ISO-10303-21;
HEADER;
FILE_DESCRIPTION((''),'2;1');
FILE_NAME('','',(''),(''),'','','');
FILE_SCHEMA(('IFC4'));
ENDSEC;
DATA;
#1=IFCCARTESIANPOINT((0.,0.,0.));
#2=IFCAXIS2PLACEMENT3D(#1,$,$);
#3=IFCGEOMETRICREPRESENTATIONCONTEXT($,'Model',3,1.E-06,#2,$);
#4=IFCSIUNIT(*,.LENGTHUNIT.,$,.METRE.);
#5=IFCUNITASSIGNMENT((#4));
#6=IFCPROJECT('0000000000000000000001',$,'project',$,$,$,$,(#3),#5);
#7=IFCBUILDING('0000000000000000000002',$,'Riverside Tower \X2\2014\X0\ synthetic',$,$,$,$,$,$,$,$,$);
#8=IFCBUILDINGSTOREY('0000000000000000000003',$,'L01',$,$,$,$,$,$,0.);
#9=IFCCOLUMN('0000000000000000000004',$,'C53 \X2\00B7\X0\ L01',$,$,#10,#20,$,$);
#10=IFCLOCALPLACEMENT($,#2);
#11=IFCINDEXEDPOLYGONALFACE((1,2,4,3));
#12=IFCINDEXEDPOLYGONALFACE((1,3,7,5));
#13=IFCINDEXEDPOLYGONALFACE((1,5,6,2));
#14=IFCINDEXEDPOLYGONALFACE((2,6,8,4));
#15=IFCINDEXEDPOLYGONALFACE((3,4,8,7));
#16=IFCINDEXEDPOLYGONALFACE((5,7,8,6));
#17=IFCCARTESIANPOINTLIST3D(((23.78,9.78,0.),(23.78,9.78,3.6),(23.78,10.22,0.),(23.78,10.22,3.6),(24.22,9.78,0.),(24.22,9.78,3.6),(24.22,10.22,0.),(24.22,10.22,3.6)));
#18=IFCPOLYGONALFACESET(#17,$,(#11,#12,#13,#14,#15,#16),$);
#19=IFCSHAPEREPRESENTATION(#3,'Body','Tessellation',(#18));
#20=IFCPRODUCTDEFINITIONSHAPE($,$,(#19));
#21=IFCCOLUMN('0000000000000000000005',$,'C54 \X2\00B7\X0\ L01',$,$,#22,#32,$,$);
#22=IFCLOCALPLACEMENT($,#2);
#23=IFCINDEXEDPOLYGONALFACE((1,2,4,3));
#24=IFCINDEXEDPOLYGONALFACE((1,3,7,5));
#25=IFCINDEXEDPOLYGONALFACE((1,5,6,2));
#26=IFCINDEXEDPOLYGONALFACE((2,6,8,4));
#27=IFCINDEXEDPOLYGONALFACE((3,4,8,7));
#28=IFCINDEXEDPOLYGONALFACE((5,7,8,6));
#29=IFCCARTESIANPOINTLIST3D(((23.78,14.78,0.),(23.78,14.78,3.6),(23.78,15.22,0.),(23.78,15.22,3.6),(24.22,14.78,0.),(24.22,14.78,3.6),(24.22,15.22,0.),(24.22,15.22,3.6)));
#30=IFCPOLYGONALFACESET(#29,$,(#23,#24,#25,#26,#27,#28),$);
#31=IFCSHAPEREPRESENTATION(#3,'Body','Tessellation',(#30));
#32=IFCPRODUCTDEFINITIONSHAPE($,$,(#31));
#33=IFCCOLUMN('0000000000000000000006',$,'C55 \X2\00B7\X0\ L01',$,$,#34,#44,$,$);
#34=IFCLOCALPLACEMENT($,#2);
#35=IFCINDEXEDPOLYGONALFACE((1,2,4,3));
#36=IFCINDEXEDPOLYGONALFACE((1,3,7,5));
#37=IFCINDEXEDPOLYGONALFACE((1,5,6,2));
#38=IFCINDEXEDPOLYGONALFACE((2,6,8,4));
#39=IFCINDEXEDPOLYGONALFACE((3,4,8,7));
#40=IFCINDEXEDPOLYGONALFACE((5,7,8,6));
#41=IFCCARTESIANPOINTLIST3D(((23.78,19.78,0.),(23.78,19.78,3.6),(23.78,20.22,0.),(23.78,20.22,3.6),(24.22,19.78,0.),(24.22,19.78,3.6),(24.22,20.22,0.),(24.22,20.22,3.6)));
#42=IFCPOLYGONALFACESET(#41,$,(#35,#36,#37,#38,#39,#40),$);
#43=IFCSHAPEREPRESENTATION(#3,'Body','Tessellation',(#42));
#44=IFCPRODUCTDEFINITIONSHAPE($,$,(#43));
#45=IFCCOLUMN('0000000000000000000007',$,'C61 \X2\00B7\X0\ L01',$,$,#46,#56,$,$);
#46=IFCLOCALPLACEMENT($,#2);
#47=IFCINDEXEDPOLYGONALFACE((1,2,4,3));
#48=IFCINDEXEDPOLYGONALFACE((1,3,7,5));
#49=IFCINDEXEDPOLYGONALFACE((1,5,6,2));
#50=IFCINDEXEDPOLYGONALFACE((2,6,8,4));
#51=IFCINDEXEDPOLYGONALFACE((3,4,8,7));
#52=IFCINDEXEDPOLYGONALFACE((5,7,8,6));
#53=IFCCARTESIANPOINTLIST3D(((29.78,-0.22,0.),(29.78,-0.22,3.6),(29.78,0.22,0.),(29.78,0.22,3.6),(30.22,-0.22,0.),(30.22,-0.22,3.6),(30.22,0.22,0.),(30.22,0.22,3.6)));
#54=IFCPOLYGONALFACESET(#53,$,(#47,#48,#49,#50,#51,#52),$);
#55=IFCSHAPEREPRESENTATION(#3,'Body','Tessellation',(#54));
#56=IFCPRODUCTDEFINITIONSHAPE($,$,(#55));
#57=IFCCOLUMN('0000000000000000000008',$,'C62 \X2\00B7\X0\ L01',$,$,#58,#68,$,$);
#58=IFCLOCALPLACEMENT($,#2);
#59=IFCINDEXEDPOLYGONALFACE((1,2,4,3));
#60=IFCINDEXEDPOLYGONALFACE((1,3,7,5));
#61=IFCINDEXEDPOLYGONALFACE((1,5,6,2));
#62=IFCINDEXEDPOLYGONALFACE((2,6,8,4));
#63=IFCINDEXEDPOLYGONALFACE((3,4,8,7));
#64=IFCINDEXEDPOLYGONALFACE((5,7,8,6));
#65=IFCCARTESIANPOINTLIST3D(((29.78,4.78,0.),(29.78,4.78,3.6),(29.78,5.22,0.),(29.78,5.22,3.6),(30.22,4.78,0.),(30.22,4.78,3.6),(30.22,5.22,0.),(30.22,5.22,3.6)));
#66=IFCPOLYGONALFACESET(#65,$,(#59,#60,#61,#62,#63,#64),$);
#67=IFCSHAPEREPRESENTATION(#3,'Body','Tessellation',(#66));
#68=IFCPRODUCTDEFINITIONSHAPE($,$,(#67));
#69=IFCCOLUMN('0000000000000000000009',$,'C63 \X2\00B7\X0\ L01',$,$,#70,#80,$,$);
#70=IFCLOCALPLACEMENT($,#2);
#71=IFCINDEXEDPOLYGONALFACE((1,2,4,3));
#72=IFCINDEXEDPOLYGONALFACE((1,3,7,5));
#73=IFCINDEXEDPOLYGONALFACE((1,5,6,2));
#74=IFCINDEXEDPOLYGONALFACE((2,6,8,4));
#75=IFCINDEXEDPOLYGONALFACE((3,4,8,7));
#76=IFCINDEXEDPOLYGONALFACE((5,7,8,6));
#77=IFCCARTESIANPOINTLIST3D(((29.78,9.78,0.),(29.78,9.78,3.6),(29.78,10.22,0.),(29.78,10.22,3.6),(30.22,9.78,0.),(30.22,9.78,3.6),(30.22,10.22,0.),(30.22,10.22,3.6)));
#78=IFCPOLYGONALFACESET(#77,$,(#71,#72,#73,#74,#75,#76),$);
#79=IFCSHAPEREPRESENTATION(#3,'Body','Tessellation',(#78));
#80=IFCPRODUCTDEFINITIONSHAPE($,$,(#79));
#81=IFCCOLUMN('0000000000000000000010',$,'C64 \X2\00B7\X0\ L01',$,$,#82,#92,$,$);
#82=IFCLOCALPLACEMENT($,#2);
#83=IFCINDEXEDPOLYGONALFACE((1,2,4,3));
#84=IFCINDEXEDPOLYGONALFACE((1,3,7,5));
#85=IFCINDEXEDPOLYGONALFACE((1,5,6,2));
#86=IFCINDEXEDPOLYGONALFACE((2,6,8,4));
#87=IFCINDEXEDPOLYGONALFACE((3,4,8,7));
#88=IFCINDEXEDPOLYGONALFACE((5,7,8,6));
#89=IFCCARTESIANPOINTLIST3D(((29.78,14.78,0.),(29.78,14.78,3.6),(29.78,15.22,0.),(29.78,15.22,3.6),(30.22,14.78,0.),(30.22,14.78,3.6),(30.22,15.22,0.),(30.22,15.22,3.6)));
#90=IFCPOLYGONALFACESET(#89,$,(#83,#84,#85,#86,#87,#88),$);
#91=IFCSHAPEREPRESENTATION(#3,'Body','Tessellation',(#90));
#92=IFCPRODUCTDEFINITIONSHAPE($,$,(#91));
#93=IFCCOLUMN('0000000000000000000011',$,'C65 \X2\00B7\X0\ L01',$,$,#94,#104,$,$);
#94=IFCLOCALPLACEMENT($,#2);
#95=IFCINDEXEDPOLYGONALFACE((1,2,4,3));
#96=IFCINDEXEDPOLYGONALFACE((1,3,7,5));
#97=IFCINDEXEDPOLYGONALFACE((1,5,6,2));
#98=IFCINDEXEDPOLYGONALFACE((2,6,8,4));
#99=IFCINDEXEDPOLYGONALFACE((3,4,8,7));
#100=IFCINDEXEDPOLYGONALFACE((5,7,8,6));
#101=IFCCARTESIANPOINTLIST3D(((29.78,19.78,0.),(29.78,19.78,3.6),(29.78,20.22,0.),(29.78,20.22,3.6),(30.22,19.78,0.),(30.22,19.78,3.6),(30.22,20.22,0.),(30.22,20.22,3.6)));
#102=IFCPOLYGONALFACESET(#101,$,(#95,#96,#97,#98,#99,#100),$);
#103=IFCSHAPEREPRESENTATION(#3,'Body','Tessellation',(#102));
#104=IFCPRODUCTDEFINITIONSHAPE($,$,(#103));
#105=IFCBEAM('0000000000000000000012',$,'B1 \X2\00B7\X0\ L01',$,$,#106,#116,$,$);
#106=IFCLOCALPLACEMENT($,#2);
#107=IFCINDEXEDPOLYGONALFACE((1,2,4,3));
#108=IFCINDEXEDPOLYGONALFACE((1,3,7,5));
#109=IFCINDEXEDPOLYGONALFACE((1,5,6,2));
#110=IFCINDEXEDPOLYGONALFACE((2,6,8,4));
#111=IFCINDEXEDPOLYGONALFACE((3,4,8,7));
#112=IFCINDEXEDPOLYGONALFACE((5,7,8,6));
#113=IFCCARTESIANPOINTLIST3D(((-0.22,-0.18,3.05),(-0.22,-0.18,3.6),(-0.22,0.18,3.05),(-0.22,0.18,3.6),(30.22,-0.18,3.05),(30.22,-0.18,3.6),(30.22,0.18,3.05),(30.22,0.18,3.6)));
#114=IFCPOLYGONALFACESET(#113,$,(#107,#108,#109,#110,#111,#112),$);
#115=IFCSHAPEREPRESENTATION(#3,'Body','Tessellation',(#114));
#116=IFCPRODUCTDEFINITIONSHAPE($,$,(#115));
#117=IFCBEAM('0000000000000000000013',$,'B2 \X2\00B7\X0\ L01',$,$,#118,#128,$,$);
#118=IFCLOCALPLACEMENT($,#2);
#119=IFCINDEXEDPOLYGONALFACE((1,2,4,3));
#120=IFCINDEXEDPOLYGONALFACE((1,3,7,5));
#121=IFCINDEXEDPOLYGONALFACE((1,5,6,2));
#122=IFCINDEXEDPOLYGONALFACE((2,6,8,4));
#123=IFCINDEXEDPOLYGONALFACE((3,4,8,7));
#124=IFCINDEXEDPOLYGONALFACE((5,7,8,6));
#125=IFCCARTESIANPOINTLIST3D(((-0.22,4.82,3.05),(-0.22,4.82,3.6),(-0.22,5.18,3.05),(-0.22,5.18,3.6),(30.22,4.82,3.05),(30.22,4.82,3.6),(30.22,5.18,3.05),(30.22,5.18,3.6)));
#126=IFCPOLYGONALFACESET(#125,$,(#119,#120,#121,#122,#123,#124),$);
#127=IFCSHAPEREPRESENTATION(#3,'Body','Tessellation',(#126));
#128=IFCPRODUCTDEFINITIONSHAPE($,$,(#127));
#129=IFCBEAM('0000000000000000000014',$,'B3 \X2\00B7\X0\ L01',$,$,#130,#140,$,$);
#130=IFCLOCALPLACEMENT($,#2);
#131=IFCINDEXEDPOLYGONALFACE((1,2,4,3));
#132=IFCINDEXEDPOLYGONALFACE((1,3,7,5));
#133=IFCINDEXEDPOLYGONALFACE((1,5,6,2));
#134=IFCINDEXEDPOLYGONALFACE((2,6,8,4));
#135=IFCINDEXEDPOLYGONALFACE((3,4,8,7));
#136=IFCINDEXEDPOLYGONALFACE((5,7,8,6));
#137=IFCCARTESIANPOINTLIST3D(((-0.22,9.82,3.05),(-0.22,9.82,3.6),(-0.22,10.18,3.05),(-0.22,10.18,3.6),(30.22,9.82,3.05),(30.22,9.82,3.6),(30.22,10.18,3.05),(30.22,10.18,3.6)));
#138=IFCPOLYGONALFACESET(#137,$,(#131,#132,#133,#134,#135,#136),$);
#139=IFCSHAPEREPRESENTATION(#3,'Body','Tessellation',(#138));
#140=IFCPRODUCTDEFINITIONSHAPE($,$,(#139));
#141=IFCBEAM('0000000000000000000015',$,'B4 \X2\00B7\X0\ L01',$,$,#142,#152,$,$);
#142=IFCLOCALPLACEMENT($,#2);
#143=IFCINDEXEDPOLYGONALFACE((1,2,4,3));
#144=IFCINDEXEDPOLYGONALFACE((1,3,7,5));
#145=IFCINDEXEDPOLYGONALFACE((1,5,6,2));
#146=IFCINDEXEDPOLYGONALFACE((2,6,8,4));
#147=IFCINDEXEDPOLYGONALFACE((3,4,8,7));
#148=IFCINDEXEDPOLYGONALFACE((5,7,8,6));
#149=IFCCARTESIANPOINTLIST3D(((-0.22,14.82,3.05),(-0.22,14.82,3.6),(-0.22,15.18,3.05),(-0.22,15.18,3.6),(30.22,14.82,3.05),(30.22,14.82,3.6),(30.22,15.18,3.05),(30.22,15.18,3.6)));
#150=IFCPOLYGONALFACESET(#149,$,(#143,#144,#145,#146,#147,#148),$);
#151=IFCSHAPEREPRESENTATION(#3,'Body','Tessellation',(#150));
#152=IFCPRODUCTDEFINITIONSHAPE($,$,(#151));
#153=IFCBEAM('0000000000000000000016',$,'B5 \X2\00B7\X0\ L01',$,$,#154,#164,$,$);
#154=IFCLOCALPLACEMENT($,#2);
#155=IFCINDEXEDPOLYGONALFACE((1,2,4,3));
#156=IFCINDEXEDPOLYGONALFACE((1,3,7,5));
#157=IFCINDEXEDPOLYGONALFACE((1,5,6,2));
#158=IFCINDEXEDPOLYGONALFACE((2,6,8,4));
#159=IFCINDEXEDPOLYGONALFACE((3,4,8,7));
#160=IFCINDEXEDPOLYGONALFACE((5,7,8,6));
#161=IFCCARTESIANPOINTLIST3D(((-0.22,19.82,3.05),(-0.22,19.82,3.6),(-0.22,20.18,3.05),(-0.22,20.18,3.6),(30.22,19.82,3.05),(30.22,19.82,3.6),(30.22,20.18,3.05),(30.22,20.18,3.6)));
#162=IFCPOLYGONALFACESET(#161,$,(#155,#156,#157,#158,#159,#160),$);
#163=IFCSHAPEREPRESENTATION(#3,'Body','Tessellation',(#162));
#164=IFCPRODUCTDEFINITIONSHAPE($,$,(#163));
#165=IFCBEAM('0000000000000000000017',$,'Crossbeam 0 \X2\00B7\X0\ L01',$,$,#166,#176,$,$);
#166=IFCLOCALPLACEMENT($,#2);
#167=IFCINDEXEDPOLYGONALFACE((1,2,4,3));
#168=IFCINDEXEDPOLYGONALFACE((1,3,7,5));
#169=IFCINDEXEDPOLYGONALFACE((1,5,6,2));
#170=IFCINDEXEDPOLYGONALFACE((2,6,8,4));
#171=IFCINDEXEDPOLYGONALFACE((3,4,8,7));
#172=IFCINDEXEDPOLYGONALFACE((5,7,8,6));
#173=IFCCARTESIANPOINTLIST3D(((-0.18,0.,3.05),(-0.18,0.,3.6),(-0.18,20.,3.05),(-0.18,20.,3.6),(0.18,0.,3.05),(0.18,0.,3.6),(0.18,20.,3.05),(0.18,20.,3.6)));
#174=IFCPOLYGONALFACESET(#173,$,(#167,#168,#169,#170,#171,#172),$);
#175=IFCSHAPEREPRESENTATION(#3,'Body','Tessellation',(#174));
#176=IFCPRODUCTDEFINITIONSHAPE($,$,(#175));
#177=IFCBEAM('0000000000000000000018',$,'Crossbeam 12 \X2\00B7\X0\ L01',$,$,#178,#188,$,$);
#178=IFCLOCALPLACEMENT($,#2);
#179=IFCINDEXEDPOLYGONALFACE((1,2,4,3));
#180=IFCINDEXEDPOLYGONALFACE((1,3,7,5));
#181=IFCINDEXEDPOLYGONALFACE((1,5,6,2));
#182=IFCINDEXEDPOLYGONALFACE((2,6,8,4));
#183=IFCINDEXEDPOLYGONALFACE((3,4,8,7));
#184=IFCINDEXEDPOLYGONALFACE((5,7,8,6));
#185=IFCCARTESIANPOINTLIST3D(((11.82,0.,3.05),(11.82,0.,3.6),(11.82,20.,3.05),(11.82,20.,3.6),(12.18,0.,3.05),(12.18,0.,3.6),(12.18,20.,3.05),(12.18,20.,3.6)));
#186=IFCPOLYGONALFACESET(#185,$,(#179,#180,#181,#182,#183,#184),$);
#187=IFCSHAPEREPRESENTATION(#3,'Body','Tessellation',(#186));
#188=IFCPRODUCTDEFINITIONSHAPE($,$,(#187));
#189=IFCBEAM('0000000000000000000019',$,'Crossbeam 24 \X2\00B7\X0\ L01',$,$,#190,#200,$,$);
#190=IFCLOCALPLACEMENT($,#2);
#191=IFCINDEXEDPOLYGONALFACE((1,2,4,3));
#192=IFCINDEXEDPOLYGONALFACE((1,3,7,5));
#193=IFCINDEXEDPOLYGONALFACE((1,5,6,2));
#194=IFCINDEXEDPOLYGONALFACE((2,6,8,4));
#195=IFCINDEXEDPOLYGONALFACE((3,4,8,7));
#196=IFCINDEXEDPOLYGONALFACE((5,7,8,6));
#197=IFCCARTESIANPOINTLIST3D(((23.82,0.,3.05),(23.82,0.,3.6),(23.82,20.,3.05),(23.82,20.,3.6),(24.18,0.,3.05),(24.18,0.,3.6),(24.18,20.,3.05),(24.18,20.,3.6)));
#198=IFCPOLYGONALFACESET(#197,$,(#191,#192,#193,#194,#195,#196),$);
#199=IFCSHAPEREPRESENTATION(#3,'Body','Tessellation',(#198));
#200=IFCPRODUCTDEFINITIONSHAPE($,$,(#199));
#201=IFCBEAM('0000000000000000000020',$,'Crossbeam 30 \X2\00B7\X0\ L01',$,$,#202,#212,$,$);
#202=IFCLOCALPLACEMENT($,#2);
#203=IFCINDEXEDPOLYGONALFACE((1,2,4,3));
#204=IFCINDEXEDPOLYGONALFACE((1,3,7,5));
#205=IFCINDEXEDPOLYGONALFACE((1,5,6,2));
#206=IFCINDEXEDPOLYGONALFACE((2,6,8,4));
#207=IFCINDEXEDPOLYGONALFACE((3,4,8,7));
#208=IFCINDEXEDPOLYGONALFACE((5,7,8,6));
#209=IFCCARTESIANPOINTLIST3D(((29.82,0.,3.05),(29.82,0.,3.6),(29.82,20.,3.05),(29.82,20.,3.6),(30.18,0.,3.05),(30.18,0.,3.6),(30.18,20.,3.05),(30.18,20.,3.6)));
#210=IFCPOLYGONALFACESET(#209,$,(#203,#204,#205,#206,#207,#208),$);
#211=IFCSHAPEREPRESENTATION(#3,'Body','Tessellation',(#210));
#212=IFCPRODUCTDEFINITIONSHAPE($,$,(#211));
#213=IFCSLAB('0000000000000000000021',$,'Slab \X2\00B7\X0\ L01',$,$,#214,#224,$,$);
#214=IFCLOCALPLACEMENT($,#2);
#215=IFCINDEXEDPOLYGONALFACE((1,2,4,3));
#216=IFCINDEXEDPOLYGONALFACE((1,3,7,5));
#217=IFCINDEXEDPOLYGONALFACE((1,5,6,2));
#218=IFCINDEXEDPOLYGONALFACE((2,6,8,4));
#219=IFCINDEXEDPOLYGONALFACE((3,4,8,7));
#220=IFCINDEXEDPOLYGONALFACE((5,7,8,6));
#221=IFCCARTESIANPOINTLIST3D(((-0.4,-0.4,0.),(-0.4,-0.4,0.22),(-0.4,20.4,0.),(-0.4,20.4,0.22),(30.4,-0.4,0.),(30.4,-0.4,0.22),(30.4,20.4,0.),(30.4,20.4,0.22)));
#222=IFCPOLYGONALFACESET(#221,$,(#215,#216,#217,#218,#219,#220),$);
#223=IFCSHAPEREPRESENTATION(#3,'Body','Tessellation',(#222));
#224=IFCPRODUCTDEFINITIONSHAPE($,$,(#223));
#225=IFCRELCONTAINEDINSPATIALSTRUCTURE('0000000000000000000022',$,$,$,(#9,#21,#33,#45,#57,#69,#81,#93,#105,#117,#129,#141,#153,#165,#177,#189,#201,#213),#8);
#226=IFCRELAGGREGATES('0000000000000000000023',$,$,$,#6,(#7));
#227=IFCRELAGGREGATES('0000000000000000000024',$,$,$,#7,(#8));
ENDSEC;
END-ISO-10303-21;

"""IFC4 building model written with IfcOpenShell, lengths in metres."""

from ifc_helpers import new_model, si_unit, frame, origin, place, context, project, spatial, rectangle, extrude, element, save


model = new_model("IFC4")

# Units and contexts
model_context = context("Model", 3, precision=1e-06, world=origin())
ifc_project = project(units=[si_unit("LENGTHUNIT", "METRE")], contexts=[model_context])

# Building, storey
building = spatial("IfcBuilding", under=ifc_project, Name="Riverside Tower — synthetic")
storey = spatial("IfcBuildingStorey", under=building, Name="L01", Elevation=0.0)

# Columns
for number, where, name in (
    (1, (24.0, 10.0, 0.0), "C53 · L01"),
    (2, (24.0, 15.0, 0.0), "C54 · L01"),
    (3, (24.0, 20.0, 0.0), "C55 · L01"),
    (4, (30.0, 0.0, 0.0), "C61 · L01"),
    (5, (30.0, 5.0, 0.0), "C62 · L01"),
    (6, (30.0, 10.0, 0.0), "C63 · L01"),
    (7, (30.0, 15.0, 0.0), "C64 · L01"),
    (8, (30.0, 20.0, 0.0), "C65 · L01"),
):
    element("IfcColumn", number, at=place(None, frame(where)), inside=storey, Name=name, context=model_context, shape_type="SweptSolid", body=[
        extrude(rectangle(XDim=0.44, YDim=0.44), origin(), (0.0, 0.0, 1.0), 3.6),
    ])

# Beams
for number, where, name in (
    (9, (15.0, 0.0, 3.05), "B1 · L01"),
    (10, (15.0, 5.0, 3.05), "B2 · L01"),
    (11, (15.0, 10.0, 3.05), "B3 · L01"),
    (12, (15.0, 15.0, 3.05), "B4 · L01"),
    (13, (15.0, 20.0, 3.05), "B5 · L01"),
):
    element("IfcBeam", number, at=place(None, frame(where)), inside=storey, Name=name, context=model_context, shape_type="SweptSolid", body=[
        extrude(rectangle(XDim=30.44, YDim=0.36), origin(), (0.0, 0.0, 1.0), 0.55),
    ])
for number, where, name in (
    (14, (0.0, 10.0, 3.05), "Crossbeam 0 · L01"),
    (15, (12.0, 10.0, 3.05), "Crossbeam 12 · L01"),
    (16, (24.0, 10.0, 3.05), "Crossbeam 24 · L01"),
    (17, (30.0, 10.0, 3.05), "Crossbeam 30 · L01"),
):
    element("IfcBeam", number, at=place(None, frame(where)), inside=storey, Name=name, context=model_context, shape_type="SweptSolid", body=[
        extrude(rectangle(XDim=0.36, YDim=20.0), origin(), (0.0, 0.0, 1.0), 0.55),
    ])

# Slab
slab_placement = place(None, frame((15.0, 10.0, 0.0)))
element("IfcSlab", 18, at=slab_placement, inside=storey, Name="Slab · L01", context=model_context, shape_type="SweptSolid", body=[
    extrude(rectangle(XDim=30.8, YDim=20.8), origin(), (0.0, 0.0, 1.0), 0.22),
])

save(model, "model.ifc")
